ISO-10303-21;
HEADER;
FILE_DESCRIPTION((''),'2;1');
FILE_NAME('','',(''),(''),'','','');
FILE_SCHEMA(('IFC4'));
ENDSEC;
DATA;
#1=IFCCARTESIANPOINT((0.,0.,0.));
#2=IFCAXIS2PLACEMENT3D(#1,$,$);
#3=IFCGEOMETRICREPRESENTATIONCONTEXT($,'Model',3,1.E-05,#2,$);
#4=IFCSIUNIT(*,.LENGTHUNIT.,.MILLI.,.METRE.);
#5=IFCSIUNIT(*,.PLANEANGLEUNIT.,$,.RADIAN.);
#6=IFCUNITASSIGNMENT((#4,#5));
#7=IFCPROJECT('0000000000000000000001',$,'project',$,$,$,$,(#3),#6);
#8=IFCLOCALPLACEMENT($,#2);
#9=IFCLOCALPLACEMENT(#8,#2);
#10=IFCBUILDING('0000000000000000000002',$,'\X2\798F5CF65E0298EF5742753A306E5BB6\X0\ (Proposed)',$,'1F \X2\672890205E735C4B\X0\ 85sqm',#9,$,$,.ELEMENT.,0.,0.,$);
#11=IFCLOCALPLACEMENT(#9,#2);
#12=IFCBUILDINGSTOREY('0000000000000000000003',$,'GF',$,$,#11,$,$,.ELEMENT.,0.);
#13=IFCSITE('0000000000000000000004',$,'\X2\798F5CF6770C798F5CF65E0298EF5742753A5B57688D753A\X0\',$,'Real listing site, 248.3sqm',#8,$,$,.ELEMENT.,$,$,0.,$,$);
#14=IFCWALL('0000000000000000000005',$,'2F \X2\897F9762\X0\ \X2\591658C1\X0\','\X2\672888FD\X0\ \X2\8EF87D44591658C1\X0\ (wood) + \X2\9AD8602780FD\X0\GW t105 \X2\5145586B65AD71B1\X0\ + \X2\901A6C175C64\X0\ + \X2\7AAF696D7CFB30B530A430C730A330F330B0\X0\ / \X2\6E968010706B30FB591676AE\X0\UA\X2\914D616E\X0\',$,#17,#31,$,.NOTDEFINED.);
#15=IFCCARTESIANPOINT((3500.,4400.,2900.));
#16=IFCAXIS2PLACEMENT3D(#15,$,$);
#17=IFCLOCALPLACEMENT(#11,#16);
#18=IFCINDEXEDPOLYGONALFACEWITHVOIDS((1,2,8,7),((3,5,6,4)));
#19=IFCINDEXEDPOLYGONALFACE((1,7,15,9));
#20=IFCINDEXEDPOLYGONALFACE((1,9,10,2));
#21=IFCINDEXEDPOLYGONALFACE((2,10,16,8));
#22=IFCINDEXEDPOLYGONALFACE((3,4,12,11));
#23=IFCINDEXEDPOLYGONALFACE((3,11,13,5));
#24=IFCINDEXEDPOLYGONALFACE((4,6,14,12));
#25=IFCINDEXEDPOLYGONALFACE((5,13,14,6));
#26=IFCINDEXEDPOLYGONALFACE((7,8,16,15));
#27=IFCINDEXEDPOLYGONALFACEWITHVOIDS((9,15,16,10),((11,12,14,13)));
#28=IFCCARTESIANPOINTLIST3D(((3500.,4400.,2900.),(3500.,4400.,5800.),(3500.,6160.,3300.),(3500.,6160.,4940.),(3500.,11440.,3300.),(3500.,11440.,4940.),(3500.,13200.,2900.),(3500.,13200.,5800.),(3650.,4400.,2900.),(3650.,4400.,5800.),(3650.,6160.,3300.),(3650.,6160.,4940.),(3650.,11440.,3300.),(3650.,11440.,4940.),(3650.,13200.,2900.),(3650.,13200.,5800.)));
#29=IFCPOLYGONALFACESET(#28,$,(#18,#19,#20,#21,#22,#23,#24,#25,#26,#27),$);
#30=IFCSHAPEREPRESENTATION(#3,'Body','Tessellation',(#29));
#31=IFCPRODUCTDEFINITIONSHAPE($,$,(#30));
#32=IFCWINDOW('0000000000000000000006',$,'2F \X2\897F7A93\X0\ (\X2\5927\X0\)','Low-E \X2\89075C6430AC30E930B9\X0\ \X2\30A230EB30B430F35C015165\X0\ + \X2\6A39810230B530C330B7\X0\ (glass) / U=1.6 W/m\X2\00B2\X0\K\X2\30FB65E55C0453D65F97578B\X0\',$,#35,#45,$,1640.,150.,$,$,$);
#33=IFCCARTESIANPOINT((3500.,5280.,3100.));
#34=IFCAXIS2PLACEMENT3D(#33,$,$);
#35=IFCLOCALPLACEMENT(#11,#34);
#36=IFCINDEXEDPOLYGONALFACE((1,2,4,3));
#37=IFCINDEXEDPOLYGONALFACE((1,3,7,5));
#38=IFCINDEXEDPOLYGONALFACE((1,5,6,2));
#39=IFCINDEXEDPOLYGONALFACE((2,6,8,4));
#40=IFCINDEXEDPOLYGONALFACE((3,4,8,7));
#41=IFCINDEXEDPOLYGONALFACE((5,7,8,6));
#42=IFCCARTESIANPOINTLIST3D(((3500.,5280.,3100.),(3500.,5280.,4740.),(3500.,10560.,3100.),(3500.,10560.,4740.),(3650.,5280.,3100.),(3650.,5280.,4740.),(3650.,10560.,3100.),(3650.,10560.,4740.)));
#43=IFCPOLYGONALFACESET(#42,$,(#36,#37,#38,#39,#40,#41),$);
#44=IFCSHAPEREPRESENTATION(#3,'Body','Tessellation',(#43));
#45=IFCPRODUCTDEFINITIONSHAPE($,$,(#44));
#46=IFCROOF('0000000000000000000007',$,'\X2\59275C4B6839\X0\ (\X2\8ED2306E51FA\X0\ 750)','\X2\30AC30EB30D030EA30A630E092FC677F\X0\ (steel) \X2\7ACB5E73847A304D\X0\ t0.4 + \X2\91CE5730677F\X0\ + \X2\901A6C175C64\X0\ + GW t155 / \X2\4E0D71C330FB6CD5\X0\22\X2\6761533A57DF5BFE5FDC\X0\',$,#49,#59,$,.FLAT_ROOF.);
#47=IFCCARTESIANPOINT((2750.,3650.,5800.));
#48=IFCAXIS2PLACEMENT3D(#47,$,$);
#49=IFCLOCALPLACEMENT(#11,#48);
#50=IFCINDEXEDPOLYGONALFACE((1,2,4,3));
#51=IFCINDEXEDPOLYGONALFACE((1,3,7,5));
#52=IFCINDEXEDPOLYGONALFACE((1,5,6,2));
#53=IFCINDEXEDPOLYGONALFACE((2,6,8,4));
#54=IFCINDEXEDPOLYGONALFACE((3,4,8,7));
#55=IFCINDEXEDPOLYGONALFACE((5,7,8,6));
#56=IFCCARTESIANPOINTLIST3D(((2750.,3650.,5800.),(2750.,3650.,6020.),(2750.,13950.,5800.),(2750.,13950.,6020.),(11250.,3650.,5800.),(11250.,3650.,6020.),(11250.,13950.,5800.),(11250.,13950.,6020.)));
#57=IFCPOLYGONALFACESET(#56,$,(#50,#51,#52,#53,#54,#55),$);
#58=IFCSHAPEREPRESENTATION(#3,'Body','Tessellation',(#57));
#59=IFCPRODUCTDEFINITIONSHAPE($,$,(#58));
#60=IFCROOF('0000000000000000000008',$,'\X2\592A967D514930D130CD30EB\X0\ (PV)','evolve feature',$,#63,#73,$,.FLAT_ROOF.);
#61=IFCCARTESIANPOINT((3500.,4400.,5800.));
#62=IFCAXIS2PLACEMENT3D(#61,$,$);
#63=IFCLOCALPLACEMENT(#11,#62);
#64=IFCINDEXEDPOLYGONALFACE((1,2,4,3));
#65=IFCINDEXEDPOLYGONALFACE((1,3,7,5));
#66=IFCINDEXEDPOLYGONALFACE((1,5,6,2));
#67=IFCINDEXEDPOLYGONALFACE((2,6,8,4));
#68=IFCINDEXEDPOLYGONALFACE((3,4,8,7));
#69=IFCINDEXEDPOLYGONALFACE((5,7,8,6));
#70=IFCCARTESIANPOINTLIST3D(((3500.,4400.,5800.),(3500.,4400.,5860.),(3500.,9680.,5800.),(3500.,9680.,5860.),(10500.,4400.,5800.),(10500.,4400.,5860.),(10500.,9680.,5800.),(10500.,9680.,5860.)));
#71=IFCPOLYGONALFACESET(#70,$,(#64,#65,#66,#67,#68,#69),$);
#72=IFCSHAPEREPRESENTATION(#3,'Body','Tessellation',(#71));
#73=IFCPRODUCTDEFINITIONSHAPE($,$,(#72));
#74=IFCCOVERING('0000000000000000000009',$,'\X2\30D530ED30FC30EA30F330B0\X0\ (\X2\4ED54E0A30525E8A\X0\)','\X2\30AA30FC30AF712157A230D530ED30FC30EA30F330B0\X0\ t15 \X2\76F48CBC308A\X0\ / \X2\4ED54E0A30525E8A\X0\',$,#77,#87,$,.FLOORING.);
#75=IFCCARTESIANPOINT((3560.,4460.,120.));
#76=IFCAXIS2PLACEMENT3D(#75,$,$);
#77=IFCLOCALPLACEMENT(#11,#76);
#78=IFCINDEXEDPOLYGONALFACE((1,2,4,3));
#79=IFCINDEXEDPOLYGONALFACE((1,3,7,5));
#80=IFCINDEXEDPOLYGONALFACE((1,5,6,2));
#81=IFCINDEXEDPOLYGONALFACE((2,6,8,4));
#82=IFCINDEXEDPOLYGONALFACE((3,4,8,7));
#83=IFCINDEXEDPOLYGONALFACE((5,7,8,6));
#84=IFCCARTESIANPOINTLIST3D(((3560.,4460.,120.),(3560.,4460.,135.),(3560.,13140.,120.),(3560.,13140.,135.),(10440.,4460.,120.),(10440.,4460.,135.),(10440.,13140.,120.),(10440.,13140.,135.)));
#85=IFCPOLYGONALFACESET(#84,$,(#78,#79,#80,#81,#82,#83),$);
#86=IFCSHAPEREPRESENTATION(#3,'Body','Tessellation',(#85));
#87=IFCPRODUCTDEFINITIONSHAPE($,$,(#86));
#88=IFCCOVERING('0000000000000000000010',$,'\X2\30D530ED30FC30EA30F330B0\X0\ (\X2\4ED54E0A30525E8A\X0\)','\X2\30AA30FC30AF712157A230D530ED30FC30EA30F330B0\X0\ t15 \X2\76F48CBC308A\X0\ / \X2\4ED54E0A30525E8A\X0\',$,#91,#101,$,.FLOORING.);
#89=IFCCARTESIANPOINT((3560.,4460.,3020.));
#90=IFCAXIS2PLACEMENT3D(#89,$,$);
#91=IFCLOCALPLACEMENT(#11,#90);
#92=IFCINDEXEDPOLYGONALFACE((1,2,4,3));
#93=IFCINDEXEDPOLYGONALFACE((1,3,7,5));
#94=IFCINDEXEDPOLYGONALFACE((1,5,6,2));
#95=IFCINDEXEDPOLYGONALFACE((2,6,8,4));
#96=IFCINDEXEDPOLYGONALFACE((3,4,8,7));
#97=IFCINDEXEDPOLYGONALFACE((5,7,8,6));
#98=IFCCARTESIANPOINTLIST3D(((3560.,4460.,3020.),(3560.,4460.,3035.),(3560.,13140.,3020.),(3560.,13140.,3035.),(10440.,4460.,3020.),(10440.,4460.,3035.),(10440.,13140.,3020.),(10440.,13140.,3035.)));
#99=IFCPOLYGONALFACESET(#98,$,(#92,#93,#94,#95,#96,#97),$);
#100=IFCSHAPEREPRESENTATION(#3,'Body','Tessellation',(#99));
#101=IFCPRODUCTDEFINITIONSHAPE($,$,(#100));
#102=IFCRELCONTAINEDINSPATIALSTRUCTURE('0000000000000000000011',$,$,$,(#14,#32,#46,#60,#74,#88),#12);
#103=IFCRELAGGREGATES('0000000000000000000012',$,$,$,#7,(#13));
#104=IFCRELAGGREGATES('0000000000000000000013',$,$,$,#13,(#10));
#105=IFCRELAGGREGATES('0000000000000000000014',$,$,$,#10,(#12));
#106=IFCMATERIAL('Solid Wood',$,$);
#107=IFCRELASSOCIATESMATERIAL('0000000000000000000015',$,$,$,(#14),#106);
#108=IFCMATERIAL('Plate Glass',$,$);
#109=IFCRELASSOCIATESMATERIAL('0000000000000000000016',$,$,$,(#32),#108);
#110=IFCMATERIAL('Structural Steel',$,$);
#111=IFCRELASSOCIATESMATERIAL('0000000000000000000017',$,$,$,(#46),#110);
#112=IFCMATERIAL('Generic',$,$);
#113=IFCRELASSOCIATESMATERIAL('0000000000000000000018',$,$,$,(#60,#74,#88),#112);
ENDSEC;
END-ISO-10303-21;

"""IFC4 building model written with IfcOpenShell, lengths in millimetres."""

from ifc_helpers import new_model, si_unit, frame, frame_2d, origin, place, context, project, spatial, rectangle, extrude, material, element, fill, save


model = new_model("IFC4")

# Units and contexts
model_context = context("Model", 3, precision=1e-05, world=origin())
ifc_project = project(units=[si_unit("LENGTHUNIT", "METRE", prefix="MILLI"), si_unit("PLANEANGLEUNIT", "RADIAN")], contexts=[model_context])

# Site, building, storey
site_placement = place(None, origin())
site = spatial("IfcSite", under=ifc_project, at=site_placement, Name="福島県福島市飯坂町字梍町", ObjectType="Real listing site, 248.3sqm", CompositionType="ELEMENT", RefElevation=0.0)
building_placement = place(site_placement, origin())
building = spatial("IfcBuilding", under=site, at=building_placement, Name="福島市飯坂町の家 (Proposed)", ObjectType="1F 木造平屋 85sqm", CompositionType="ELEMENT", ElevationOfRefHeight=0.0, ElevationOfTerrain=0.0)
storey_placement = place(building_placement, origin())
storey = spatial("IfcBuildingStorey", under=building, at=storey_placement, Name="GF", CompositionType="ELEMENT", Elevation=0.0)

# Shared definitions
ifc_material_1 = material(Name="Solid Wood")
ifc_material_2 = material(Name="Generic")

# Shared definitions
ifc_material_3 = material(Name="Plate Glass")

# Wall, opening, window
wall_1_placement = place(storey_placement, frame((3500.0, 4400.0, 2900.0)))
wall_1 = element("IfcWall", 1, at=wall_1_placement, inside=storey, material=ifc_material_1, Name="2F 西面 外壁", Description="木製 軸組外壁 (wood) + 高性能GW t105 充填断熱 + 通気層 + 窯業系サイディング / 準耐火・外皮UA配慮", PredefinedType="NOTDEFINED", context=model_context, shape_type="SweptSolid", body=[
    extrude(rectangle(XDim=150.0, YDim=8800.0, at=frame_2d((75.0, 4400.0))), frame((3500.0, 4400.0, 2900.0)), (0.0, 0.0, 1.0), 2900.0),
])
opening_1_placement = place(storey_placement, frame((3500.0, 5280.0, 3100.0)))
opening_1 = element("IfcOpeningElement", 2, at=opening_1_placement, cuts=wall_1, PredefinedType="NOTDEFINED", context=model_context, shape_type="SweptSolid", body=[
    extrude(rectangle(XDim=150.0, YDim=5280.0, at=frame_2d((75.0, 2640.0))), frame((3500.0, 5280.0, 3100.0)), (0.0, 0.0, 1.0), 1640.0),
])
window_1_placement = place(storey_placement, frame((3500.0, 5280.0, 3100.0)))
window_1 = element("IfcWindow", 3, at=window_1_placement, inside=storey, material=ifc_material_3, Name="2F 西窓 (大)", Description="Low-E 複層ガラス アルゴン封入 + 樹脂サッシ (glass) / U=1.6 W/m²K・日射取得型", OverallHeight=1640.0, OverallWidth=150.0, context=model_context, shape_type="SweptSolid", body=[
    extrude(rectangle(XDim=150.0, YDim=5280.0, at=frame_2d((75.0, 2640.0))), frame((3500.0, 5280.0, 3100.0)), (0.0, 0.0, 1.0), 1640.0),
])
fill(opening_1, window_1)

# Roofs
ifc_material_4 = material(Name="Structural Steel")
roof_1_placement = place(storey_placement, frame((2750.0, 3650.0, 5800.0)))
element("IfcRoof", 4, at=roof_1_placement, inside=storey, material=ifc_material_4, Name="大屋根 (軒の出 750)", Description="ガルバリウム鋼板 (steel) 立平葺き t0.4 + 野地板 + 通気層 + GW t155 / 不燃・法22条区域対応", PredefinedType="FLAT_ROOF", context=model_context, shape_type="SweptSolid", body=[
    extrude(rectangle(XDim=8500.0, YDim=10300.0, at=frame_2d((4250.0, 5150.0))), frame((2750.0, 3650.0, 5800.0)), (0.0, 0.0, 1.0), 220.0),
])
roof_2_placement = place(storey_placement, frame((3500.0, 4400.0, 5800.0)))
element("IfcRoof", 5, at=roof_2_placement, inside=storey, material=ifc_material_2, Name="太陽光パネル (PV)", Description="evolve feature", PredefinedType="FLAT_ROOF", context=model_context, shape_type="SweptSolid", body=[
    extrude(rectangle(XDim=7000.0, YDim=5280.0, at=frame_2d((3500.0, 2640.0))), frame((3500.0, 4400.0, 5800.0)), (0.0, 0.0, 1.0), 60.0),
])

# Coverings
covering_1_placement = place(storey_placement, frame((3560.0, 4460.0, 120.0)))
element("IfcCovering", 6, at=covering_1_placement, inside=storey, material=ifc_material_2, Name="フローリング (仕上げ床)", Description="オーク無垢フローリング t15 直貼り / 仕上げ床", PredefinedType="FLOORING", context=model_context, shape_type="SweptSolid", body=[
    extrude(rectangle(XDim=6880.0, YDim=8680.0, at=frame_2d((3440.0, 4340.0))), frame((3560.0, 4460.0, 120.0)), (0.0, 0.0, 1.0), 15.0),
])
covering_2_placement = place(storey_placement, frame((3560.0, 4460.0, 3020.0)))
element("IfcCovering", 7, at=covering_2_placement, inside=storey, material=ifc_material_2, Name="フローリング (仕上げ床)", Description="オーク無垢フローリング t15 直貼り / 仕上げ床", PredefinedType="FLOORING", context=model_context, shape_type="SweptSolid", body=[
    extrude(rectangle(XDim=6880.0, YDim=8680.0, at=frame_2d((3440.0, 4340.0))), frame((3560.0, 4460.0, 3020.0)), (0.0, 0.0, 1.0), 15.0),
])

save(model, "model.ifc")
